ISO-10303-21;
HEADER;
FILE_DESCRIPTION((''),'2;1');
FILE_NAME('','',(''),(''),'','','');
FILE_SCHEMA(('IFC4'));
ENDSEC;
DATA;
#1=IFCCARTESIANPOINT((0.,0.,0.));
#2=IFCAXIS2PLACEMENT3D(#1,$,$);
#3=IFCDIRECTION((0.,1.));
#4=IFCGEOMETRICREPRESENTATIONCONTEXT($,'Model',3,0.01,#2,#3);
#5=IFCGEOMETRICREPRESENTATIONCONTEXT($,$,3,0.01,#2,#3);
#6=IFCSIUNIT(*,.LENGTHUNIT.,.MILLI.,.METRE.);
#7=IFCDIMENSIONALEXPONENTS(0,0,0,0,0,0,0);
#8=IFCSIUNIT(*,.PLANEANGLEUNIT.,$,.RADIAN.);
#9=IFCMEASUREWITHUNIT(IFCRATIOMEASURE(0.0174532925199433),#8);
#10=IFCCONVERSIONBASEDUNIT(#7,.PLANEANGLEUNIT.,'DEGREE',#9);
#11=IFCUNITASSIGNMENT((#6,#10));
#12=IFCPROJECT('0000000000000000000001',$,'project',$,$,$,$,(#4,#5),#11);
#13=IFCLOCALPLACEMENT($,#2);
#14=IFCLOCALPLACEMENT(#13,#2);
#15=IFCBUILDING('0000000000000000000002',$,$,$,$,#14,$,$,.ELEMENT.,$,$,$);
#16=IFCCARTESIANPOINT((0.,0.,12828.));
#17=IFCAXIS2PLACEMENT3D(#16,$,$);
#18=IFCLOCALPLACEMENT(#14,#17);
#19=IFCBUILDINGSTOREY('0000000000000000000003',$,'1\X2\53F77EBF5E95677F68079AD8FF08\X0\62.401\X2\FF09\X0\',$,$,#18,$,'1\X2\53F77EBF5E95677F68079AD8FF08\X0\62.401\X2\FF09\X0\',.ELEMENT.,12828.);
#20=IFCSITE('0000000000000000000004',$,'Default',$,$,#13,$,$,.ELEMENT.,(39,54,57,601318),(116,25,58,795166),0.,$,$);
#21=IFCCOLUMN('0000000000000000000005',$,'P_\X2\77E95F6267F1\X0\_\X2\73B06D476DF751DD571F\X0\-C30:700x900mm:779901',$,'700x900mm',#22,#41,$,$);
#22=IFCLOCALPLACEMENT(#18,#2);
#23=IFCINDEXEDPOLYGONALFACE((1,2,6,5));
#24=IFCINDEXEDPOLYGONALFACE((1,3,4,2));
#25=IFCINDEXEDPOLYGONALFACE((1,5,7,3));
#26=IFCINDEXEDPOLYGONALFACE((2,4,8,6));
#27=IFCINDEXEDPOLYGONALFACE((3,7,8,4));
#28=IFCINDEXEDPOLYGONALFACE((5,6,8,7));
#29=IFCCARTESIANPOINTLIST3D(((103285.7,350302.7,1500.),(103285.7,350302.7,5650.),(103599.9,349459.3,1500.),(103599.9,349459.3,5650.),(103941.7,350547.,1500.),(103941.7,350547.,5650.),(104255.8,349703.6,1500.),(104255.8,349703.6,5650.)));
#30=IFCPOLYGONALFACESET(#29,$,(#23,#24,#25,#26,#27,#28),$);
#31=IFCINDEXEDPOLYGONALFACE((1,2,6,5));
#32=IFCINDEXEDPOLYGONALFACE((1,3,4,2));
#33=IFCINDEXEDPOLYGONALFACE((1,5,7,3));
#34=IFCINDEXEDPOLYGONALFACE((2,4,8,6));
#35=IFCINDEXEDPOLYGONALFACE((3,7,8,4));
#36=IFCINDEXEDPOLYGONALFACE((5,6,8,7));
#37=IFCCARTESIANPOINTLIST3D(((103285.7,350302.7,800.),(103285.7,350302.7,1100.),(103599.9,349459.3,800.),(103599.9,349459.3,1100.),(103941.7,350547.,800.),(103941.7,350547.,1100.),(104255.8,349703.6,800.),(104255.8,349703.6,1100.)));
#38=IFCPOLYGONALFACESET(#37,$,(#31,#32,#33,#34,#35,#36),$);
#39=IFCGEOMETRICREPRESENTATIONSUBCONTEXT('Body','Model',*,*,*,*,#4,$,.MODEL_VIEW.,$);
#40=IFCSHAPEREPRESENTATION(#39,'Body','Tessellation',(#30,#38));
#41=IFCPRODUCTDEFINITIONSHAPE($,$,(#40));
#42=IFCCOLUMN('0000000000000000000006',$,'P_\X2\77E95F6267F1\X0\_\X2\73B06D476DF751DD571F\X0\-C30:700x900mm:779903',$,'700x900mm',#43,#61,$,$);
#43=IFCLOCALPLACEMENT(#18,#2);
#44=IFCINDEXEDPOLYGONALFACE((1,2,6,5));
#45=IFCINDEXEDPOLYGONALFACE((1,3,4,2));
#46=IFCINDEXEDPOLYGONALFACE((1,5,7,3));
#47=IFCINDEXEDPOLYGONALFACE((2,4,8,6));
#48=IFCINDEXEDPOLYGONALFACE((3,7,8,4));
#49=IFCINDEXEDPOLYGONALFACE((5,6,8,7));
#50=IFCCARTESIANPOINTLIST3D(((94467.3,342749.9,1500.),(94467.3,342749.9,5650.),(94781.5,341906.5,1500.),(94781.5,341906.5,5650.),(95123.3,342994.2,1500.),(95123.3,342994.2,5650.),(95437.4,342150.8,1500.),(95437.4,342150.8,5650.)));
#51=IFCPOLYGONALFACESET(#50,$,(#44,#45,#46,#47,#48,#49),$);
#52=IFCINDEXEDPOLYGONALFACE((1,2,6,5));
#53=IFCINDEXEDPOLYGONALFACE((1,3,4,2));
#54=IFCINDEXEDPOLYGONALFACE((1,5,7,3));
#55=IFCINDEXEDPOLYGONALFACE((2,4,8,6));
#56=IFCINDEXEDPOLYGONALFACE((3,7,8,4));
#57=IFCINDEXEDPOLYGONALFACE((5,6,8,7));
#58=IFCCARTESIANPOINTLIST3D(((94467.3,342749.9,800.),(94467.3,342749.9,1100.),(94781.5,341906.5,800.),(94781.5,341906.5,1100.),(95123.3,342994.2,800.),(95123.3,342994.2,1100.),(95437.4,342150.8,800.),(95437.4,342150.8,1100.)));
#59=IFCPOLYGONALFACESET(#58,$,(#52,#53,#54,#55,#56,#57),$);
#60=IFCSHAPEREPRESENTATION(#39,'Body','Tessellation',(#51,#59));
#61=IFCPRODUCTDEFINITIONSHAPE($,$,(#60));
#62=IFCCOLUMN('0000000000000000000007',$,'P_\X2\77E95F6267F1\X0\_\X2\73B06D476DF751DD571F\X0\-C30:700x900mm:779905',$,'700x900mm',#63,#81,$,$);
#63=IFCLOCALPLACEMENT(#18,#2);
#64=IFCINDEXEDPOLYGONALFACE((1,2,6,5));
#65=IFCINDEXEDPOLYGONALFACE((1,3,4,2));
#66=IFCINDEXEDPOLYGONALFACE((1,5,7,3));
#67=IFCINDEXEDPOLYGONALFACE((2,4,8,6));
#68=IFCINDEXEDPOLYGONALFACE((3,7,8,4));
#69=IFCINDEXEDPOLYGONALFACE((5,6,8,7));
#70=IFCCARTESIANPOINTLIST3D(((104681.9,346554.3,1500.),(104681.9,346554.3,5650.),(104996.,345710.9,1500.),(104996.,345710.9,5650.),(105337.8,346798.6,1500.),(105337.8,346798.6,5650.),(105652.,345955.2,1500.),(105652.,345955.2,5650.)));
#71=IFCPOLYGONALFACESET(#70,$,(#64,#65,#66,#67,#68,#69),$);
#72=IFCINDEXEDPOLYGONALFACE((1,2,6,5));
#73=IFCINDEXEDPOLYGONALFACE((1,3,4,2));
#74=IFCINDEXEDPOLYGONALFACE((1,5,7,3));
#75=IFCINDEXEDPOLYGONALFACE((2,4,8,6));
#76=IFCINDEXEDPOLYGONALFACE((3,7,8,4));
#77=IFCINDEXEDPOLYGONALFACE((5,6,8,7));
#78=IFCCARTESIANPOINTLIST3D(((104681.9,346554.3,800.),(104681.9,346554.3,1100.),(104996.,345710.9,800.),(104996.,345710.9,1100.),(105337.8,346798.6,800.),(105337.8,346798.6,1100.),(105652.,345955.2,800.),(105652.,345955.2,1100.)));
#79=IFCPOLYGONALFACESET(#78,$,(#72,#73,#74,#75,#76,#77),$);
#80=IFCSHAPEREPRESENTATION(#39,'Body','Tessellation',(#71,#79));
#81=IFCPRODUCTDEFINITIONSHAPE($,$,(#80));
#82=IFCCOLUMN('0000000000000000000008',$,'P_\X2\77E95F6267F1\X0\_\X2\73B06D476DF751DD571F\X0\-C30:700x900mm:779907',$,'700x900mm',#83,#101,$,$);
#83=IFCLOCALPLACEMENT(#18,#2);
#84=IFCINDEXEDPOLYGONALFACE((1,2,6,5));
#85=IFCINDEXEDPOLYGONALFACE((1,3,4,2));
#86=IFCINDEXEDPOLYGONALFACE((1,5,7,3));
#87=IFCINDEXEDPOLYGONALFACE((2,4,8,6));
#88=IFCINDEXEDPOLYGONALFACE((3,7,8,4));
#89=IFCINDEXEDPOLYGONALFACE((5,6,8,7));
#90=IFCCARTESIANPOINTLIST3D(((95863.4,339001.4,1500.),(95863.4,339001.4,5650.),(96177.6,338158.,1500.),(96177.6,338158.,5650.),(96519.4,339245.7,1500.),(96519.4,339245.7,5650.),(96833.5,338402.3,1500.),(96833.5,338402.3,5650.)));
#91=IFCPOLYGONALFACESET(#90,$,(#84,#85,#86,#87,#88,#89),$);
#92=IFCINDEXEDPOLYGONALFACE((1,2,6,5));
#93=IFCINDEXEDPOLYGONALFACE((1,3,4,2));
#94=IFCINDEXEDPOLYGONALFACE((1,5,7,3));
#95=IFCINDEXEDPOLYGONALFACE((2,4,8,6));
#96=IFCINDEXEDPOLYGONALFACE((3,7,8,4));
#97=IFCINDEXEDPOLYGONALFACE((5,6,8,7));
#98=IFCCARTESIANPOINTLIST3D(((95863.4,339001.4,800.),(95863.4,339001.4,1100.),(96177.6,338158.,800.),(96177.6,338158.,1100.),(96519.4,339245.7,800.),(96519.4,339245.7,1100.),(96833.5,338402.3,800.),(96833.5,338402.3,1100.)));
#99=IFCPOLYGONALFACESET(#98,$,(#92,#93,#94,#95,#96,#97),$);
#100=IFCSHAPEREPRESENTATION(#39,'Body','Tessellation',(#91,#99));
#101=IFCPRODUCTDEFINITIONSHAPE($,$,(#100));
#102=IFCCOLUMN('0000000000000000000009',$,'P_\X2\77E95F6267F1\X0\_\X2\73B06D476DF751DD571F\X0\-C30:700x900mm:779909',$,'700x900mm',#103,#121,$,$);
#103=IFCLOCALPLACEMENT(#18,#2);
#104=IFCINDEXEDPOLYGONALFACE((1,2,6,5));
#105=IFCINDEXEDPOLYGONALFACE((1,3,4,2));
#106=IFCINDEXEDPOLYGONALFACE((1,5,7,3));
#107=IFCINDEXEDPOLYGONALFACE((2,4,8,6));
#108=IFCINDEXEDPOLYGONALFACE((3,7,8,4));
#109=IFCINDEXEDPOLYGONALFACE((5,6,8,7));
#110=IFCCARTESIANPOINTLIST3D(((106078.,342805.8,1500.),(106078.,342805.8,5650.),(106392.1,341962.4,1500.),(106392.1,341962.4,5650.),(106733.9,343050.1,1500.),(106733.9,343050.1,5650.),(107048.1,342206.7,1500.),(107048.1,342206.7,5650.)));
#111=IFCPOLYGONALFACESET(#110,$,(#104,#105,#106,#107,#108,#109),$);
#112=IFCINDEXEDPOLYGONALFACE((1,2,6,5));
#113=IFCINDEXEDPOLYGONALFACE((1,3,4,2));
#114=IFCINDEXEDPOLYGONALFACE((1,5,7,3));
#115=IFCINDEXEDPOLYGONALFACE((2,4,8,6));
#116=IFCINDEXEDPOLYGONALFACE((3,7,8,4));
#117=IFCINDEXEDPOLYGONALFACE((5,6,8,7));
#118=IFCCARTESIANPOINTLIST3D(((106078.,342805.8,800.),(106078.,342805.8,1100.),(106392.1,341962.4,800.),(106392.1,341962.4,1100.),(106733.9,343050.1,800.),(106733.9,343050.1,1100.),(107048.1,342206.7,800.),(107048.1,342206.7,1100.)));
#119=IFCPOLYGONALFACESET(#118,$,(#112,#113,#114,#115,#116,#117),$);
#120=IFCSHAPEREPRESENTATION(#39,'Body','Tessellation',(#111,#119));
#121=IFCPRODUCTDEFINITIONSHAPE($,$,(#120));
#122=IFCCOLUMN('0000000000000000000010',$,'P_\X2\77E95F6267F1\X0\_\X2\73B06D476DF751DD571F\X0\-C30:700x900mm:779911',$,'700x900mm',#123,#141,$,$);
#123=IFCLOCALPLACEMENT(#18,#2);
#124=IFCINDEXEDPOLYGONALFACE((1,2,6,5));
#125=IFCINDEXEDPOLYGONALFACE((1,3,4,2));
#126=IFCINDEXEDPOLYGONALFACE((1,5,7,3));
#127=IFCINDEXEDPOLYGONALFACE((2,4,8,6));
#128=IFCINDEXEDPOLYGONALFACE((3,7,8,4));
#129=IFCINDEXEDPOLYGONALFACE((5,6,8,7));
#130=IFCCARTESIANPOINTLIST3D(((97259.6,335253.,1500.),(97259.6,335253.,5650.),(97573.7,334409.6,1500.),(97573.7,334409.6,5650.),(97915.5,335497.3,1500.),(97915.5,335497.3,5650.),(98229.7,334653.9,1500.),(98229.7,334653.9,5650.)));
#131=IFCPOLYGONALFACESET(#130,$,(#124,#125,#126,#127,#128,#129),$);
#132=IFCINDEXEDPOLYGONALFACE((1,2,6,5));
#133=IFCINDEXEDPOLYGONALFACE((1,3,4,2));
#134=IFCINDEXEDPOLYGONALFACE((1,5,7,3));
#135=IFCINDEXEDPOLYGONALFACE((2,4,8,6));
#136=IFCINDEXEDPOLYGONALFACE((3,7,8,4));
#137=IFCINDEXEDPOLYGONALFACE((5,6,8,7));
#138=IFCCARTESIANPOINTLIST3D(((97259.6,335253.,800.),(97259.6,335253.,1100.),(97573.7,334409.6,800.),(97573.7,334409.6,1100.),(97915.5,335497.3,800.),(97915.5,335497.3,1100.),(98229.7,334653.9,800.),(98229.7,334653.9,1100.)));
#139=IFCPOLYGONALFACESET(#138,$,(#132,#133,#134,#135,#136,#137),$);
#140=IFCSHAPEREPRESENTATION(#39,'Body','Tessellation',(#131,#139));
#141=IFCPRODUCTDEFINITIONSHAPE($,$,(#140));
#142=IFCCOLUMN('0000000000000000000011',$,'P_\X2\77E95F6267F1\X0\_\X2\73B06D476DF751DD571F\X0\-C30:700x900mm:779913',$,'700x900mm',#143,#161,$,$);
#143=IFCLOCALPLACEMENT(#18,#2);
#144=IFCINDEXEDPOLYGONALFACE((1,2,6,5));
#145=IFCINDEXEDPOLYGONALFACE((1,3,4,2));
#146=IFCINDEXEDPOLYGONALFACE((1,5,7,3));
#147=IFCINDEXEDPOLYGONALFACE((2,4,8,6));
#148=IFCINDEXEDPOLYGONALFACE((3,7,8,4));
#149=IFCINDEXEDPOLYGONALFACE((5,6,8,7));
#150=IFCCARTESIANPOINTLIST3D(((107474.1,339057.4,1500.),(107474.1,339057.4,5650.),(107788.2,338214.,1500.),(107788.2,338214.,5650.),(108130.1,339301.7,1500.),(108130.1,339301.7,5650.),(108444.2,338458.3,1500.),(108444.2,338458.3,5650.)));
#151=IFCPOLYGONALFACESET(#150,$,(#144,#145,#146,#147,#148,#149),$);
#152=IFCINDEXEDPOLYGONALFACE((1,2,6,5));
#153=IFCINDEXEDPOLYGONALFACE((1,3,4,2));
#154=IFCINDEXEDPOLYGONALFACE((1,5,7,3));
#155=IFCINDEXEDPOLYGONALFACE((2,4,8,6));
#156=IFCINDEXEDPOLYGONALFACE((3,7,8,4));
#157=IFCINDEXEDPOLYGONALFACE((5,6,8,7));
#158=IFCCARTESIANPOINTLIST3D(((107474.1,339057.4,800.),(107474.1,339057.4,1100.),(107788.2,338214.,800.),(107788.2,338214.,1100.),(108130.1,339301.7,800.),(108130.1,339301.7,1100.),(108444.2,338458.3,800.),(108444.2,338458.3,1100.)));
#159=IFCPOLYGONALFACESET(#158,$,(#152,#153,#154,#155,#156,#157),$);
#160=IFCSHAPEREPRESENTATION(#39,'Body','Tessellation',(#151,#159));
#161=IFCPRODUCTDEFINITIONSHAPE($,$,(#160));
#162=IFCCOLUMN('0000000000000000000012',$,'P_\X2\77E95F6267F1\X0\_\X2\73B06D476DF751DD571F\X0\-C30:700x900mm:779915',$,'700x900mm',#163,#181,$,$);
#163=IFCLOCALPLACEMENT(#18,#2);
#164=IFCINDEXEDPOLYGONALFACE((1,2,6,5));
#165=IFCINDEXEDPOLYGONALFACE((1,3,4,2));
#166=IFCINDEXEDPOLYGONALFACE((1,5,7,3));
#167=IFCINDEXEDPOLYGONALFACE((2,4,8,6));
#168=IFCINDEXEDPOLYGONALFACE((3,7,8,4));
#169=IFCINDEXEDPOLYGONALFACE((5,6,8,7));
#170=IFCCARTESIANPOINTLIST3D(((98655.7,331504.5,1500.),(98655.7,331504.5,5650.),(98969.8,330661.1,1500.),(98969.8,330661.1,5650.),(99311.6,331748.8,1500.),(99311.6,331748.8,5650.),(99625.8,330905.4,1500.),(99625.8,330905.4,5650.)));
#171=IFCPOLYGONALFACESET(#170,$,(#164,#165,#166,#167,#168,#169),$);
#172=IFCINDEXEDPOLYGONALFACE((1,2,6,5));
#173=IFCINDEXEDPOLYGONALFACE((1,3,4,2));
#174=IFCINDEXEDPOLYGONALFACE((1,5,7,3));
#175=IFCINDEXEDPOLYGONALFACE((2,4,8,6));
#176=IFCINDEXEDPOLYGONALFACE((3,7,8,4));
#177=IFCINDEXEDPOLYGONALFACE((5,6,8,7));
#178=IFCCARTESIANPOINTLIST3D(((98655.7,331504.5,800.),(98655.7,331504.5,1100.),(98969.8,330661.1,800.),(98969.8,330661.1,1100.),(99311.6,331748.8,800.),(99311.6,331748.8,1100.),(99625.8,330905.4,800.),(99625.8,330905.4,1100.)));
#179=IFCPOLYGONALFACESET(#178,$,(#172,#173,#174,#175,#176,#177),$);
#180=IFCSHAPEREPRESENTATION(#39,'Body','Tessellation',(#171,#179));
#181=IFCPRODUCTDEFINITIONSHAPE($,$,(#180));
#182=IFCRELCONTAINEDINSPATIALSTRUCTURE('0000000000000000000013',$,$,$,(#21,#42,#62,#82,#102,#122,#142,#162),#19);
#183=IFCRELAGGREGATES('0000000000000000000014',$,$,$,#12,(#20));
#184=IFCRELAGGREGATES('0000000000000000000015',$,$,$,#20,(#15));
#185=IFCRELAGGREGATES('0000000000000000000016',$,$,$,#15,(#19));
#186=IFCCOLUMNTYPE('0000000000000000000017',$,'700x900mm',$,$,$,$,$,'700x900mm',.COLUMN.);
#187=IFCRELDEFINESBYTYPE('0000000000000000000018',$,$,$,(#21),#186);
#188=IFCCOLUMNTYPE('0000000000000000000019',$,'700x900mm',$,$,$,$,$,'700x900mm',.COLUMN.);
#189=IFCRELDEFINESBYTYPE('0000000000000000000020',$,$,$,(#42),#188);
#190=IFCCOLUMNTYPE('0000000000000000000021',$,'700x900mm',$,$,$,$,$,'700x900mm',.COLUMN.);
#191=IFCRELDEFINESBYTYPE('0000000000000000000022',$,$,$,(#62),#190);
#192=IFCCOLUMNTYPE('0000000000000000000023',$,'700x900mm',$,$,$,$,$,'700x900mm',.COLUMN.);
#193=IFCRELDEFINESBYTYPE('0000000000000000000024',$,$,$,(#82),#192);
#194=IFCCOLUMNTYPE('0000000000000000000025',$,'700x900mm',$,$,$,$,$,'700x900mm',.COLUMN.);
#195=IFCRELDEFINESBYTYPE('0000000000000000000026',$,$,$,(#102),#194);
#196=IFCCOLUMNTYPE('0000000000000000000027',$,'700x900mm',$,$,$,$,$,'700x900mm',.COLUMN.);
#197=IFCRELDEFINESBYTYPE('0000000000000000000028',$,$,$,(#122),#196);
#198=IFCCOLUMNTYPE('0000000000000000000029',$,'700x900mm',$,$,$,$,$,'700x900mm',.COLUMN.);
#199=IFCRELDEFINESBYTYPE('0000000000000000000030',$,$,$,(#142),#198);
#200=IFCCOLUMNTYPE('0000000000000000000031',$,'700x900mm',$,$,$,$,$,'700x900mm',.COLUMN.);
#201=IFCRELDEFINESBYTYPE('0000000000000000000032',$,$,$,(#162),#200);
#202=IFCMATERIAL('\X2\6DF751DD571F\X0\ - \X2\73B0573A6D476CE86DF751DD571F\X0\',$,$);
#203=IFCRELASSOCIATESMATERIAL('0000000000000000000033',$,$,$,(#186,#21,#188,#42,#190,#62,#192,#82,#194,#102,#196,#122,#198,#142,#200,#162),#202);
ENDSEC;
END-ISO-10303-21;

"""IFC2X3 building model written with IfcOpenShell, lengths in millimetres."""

from ifc_helpers import new_model, entity, si_unit, converted_unit, direction, frame, frame_2d, origin, origin_2d_with_axis, place, context, subcontext, project, spatial, rectangle, extrude, source, transform, mapped, material, type_object, type_shapes, element, save


model = new_model("IFC2X3")

# Units and contexts
model_context = context("Model", 3, precision=0.01, world=origin(), true_north=direction((0.0, 1.0)))
context_of_model = context(None, 3, precision=0.01, world=origin(), true_north=direction((0.0, 1.0)))
body_context = subcontext(model_context, "Body", "Model", "MODEL_VIEW")
ifc_project = project(units=[si_unit("LENGTHUNIT", "METRE", prefix="MILLI"), converted_unit("PLANEANGLEUNIT", "DEGREE", entity("IfcRatioMeasure", 0.0174532925199433), si_unit("PLANEANGLEUNIT", "RADIAN"), dimensions=[0, 0, 0, 0, 0, 0, 0])], contexts=[model_context, context_of_model])

# Site, building, storey
site_placement = place(None, origin())
site = spatial("IfcSite", under=ifc_project, at=site_placement, Name="Default", CompositionType="ELEMENT", RefLatitude=(39, 54, 57, 601318), RefLongitude=(116, 25, 58, 795166), RefElevation=0.0)
building_placement = place(site_placement, origin())
building = spatial("IfcBuilding", under=site, at=building_placement, CompositionType="ELEMENT")
storey_placement = place(building_placement, frame((0.0, 0.0, 12828.0)))
storey = spatial("IfcBuildingStorey", under=building, at=storey_placement, Name="1号线底板标高（62.401）", LongName="1号线底板标高（62.401）", CompositionType="ELEMENT", Elevation=12828.0)

# Columns
ifc_material_1 = material(Name="混凝土 - 现场浇注混凝土")
column_type_1 = type_object("IfcColumnType", Name="700x900mm", ElementType="700x900mm", PredefinedType="COLUMN", material=ifc_material_1)
shared_shape_1 = source(origin(), body_context, "Body", "SweptSolid", [
    extrude(rectangle(XDim=700.0, YDim=900.0, at=frame_2d((0.0, 0.0), x_axis=(1.0, 0.0))), frame((485.1, 543.9, 700.0), z_axis=(0.0, 0.0, 1.0), x_axis=(-0.937112, -0.349028, 0.0)), (0.0, 0.0, 1.0), 4150.0),
    extrude(rectangle(XDim=700.0, YDim=900.0, at=frame_2d((0.0, 0.0), x_axis=(1.0, 0.0))), frame((485.1, 543.9, 0.0), z_axis=(0.0, 0.0, 1.0), x_axis=(-0.937112, -0.349028, 0.0)), (0.0, 0.0, 1.0), 300.0),
])
type_shapes(column_type_1, [shared_shape_1])
column_1_placement = place(storey_placement, frame((103285.7, 349459.3, 800.0)))
element("IfcColumn", 1, at=column_1_placement, inside=storey, type_object=column_type_1, material=ifc_material_1, Name="P_矩形柱_现浇混凝土-C30:700x900mm:779901", ObjectType="700x900mm", context=body_context, shape_type="MappedRepresentation", body=[
    mapped(shared_shape_1, transform((0.0, 0.0, 0.0), scale=1.0)),
])
column_type_2 = type_object("IfcColumnType", Name="700x900mm", ElementType="700x900mm", PredefinedType="COLUMN", material=ifc_material_1)
shared_shape_2 = source(origin(), body_context, "Body", "SweptSolid", [
    extrude(rectangle(XDim=700.0, YDim=900.0, at=origin_2d_with_axis()), frame((485.1, 543.9, 700.0), z_axis=(0.0, 0.0, 1.0), x_axis=(-0.937112, -0.349028, 0.0)), (0.0, 0.0, 1.0), 4150.0),
    extrude(rectangle(XDim=700.0, YDim=900.0, at=origin_2d_with_axis()), frame((485.1, 543.9, 0.0), z_axis=(0.0, 0.0, 1.0), x_axis=(-0.937112, -0.349028, 0.0)), (0.0, 0.0, 1.0), 300.0),
])
type_shapes(column_type_2, [shared_shape_2])
column_2_placement = place(storey_placement, frame((94467.3, 341906.5, 800.0)))
element("IfcColumn", 2, at=column_2_placement, inside=storey, type_object=column_type_2, material=ifc_material_1, Name="P_矩形柱_现浇混凝土-C30:700x900mm:779903", ObjectType="700x900mm", context=body_context, shape_type="MappedRepresentation", body=[
    mapped(shared_shape_2, transform((0.0, 0.0, 0.0), scale=1.0)),
])
column_type_3 = type_object("IfcColumnType", Name="700x900mm", ElementType="700x900mm", PredefinedType="COLUMN", material=ifc_material_1)
shared_shape_3 = source(origin(), body_context, "Body", "SweptSolid", [
    extrude(rectangle(XDim=700.0, YDim=900.0, at=frame_2d((0.0, 0.0), x_axis=(1.0, 0.0))), frame((485.1, 543.9, 700.0), z_axis=(0.0, 0.0, 1.0), x_axis=(-0.937112, -0.349028, 0.0)), (0.0, 0.0, 1.0), 4150.0),
    extrude(rectangle(XDim=700.0, YDim=900.0, at=frame_2d((0.0, 0.0), x_axis=(1.0, 0.0))), frame((485.1, 543.9, 0.0), z_axis=(0.0, 0.0, 1.0), x_axis=(-0.937112, -0.349028, 0.0)), (0.0, 0.0, 1.0), 300.0),
])
type_shapes(column_type_3, [shared_shape_3])
column_3_placement = place(storey_placement, frame((104681.9, 345710.9, 800.0)))
element("IfcColumn", 3, at=column_3_placement, inside=storey, type_object=column_type_3, material=ifc_material_1, Name="P_矩形柱_现浇混凝土-C30:700x900mm:779905", ObjectType="700x900mm", context=body_context, shape_type="MappedRepresentation", body=[
    mapped(shared_shape_3, transform((0.0, 0.0, 0.0), scale=1.0)),
])
column_type_4 = type_object("IfcColumnType", Name="700x900mm", ElementType="700x900mm", PredefinedType="COLUMN", material=ifc_material_1)
shared_shape_4 = source(origin(), body_context, "Body", "SweptSolid", [
    extrude(rectangle(XDim=700.0, YDim=900.0, at=frame_2d((0.0, 0.0), x_axis=(1.0, 0.0))), frame((485.1, 543.9, 700.0), z_axis=(0.0, 0.0, 1.0), x_axis=(-0.937112, -0.349028, 0.0)), (0.0, 0.0, 1.0), 4150.0),
    extrude(rectangle(XDim=700.0, YDim=900.0, at=frame_2d((0.0, 0.0), x_axis=(1.0, 0.0))), frame((485.1, 543.9, 0.0), z_axis=(0.0, 0.0, 1.0), x_axis=(-0.937112, -0.349028, 0.0)), (0.0, 0.0, 1.0), 300.0),
])
type_shapes(column_type_4, [shared_shape_4])
column_4_placement = place(storey_placement, frame((95863.4, 338158.0, 800.0)))
element("IfcColumn", 4, at=column_4_placement, inside=storey, type_object=column_type_4, material=ifc_material_1, Name="P_矩形柱_现浇混凝土-C30:700x900mm:779907", ObjectType="700x900mm", context=body_context, shape_type="MappedRepresentation", body=[
    mapped(shared_shape_4, transform((0.0, 0.0, 0.0), scale=1.0)),
])
column_type_5 = type_object("IfcColumnType", Name="700x900mm", ElementType="700x900mm", PredefinedType="COLUMN", material=ifc_material_1)
shared_shape_5 = source(origin(), body_context, "Body", "SweptSolid", [
    extrude(rectangle(XDim=700.0, YDim=900.0, at=frame_2d((0.0, 0.0), x_axis=(1.0, 0.0))), frame((485.1, 543.9, 700.0), z_axis=(0.0, 0.0, 1.0), x_axis=(-0.937112, -0.349028, 0.0)), (0.0, 0.0, 1.0), 4150.0),
    extrude(rectangle(XDim=700.0, YDim=900.0, at=frame_2d((0.0, 0.0), x_axis=(1.0, 0.0))), frame((485.1, 543.9, 0.0), z_axis=(0.0, 0.0, 1.0), x_axis=(-0.937112, -0.349028, 0.0)), (0.0, 0.0, 1.0), 300.0),
])
type_shapes(column_type_5, [shared_shape_5])
column_5_placement = place(storey_placement, frame((106078.0, 341962.4, 800.0)))
element("IfcColumn", 5, at=column_5_placement, inside=storey, type_object=column_type_5, material=ifc_material_1, Name="P_矩形柱_现浇混凝土-C30:700x900mm:779909", ObjectType="700x900mm", context=body_context, shape_type="MappedRepresentation", body=[
    mapped(shared_shape_5, transform((0.0, 0.0, 0.0), scale=1.0)),
])
column_type_6 = type_object("IfcColumnType", Name="700x900mm", ElementType="700x900mm", PredefinedType="COLUMN", material=ifc_material_1)
shared_shape_6 = source(origin(), body_context, "Body", "SweptSolid", [
    extrude(rectangle(XDim=700.0, YDim=900.0, at=origin_2d_with_axis()), frame((485.1, 543.9, 700.0), z_axis=(0.0, 0.0, 1.0), x_axis=(-0.937112, -0.349028, 0.0)), (0.0, 0.0, 1.0), 4150.0),
    extrude(rectangle(XDim=700.0, YDim=900.0, at=origin_2d_with_axis()), frame((485.1, 543.9, 0.0), z_axis=(0.0, 0.0, 1.0), x_axis=(-0.937112, -0.349028, 0.0)), (0.0, 0.0, 1.0), 300.0),
])
type_shapes(column_type_6, [shared_shape_6])
column_6_placement = place(storey_placement, frame((97259.6, 334409.6, 800.0)))
element("IfcColumn", 6, at=column_6_placement, inside=storey, type_object=column_type_6, material=ifc_material_1, Name="P_矩形柱_现浇混凝土-C30:700x900mm:779911", ObjectType="700x900mm", context=body_context, shape_type="MappedRepresentation", body=[
    mapped(shared_shape_6, transform((0.0, 0.0, 0.0), scale=1.0)),
])
column_type_7 = type_object("IfcColumnType", Name="700x900mm", ElementType="700x900mm", PredefinedType="COLUMN", material=ifc_material_1)
shared_shape_7 = source(origin(), body_context, "Body", "SweptSolid", [
    extrude(rectangle(XDim=700.0, YDim=900.0, at=frame_2d((0.0, 0.0), x_axis=(1.0, 0.0))), frame((485.1, 543.9, 700.0), z_axis=(0.0, 0.0, 1.0), x_axis=(-0.937112, -0.349028, 0.0)), (0.0, 0.0, 1.0), 4150.0),
    extrude(rectangle(XDim=700.0, YDim=900.0, at=frame_2d((0.0, 0.0), x_axis=(1.0, 0.0))), frame((485.1, 543.9, 0.0), z_axis=(0.0, 0.0, 1.0), x_axis=(-0.937112, -0.349028, 0.0)), (0.0, 0.0, 1.0), 300.0),
])
type_shapes(column_type_7, [shared_shape_7])
column_7_placement = place(storey_placement, frame((107474.1, 338214.0, 800.0)))
element("IfcColumn", 7, at=column_7_placement, inside=storey, type_object=column_type_7, material=ifc_material_1, Name="P_矩形柱_现浇混凝土-C30:700x900mm:779913", ObjectType="700x900mm", context=body_context, shape_type="MappedRepresentation", body=[
    mapped(shared_shape_7, transform((0.0, 0.0, 0.0), scale=1.0)),
])
column_type_8 = type_object("IfcColumnType", Name="700x900mm", ElementType="700x900mm", PredefinedType="COLUMN", material=ifc_material_1)
shared_shape_8 = source(origin(), body_context, "Body", "SweptSolid", [
    extrude(rectangle(XDim=700.0, YDim=900.0, at=frame_2d((0.0, 0.0), x_axis=(1.0, 0.0))), frame((485.1, 543.9, 700.0), z_axis=(0.0, 0.0, 1.0), x_axis=(-0.937112, -0.349028, 0.0)), (0.0, 0.0, 1.0), 4150.0),
    extrude(rectangle(XDim=700.0, YDim=900.0, at=frame_2d((0.0, 0.0), x_axis=(1.0, 0.0))), frame((485.1, 543.9, 0.0), z_axis=(0.0, 0.0, 1.0), x_axis=(-0.937112, -0.349028, 0.0)), (0.0, 0.0, 1.0), 300.0),
])
type_shapes(column_type_8, [shared_shape_8])
column_8_placement = place(storey_placement, frame((98655.7, 330661.1, 800.0)))
element("IfcColumn", 8, at=column_8_placement, inside=storey, type_object=column_type_8, material=ifc_material_1, Name="P_矩形柱_现浇混凝土-C30:700x900mm:779915", ObjectType="700x900mm", context=body_context, shape_type="MappedRepresentation", body=[
    mapped(shared_shape_8, transform((0.0, 0.0, 0.0), scale=1.0)),
])

save(model, "model.ifc")
